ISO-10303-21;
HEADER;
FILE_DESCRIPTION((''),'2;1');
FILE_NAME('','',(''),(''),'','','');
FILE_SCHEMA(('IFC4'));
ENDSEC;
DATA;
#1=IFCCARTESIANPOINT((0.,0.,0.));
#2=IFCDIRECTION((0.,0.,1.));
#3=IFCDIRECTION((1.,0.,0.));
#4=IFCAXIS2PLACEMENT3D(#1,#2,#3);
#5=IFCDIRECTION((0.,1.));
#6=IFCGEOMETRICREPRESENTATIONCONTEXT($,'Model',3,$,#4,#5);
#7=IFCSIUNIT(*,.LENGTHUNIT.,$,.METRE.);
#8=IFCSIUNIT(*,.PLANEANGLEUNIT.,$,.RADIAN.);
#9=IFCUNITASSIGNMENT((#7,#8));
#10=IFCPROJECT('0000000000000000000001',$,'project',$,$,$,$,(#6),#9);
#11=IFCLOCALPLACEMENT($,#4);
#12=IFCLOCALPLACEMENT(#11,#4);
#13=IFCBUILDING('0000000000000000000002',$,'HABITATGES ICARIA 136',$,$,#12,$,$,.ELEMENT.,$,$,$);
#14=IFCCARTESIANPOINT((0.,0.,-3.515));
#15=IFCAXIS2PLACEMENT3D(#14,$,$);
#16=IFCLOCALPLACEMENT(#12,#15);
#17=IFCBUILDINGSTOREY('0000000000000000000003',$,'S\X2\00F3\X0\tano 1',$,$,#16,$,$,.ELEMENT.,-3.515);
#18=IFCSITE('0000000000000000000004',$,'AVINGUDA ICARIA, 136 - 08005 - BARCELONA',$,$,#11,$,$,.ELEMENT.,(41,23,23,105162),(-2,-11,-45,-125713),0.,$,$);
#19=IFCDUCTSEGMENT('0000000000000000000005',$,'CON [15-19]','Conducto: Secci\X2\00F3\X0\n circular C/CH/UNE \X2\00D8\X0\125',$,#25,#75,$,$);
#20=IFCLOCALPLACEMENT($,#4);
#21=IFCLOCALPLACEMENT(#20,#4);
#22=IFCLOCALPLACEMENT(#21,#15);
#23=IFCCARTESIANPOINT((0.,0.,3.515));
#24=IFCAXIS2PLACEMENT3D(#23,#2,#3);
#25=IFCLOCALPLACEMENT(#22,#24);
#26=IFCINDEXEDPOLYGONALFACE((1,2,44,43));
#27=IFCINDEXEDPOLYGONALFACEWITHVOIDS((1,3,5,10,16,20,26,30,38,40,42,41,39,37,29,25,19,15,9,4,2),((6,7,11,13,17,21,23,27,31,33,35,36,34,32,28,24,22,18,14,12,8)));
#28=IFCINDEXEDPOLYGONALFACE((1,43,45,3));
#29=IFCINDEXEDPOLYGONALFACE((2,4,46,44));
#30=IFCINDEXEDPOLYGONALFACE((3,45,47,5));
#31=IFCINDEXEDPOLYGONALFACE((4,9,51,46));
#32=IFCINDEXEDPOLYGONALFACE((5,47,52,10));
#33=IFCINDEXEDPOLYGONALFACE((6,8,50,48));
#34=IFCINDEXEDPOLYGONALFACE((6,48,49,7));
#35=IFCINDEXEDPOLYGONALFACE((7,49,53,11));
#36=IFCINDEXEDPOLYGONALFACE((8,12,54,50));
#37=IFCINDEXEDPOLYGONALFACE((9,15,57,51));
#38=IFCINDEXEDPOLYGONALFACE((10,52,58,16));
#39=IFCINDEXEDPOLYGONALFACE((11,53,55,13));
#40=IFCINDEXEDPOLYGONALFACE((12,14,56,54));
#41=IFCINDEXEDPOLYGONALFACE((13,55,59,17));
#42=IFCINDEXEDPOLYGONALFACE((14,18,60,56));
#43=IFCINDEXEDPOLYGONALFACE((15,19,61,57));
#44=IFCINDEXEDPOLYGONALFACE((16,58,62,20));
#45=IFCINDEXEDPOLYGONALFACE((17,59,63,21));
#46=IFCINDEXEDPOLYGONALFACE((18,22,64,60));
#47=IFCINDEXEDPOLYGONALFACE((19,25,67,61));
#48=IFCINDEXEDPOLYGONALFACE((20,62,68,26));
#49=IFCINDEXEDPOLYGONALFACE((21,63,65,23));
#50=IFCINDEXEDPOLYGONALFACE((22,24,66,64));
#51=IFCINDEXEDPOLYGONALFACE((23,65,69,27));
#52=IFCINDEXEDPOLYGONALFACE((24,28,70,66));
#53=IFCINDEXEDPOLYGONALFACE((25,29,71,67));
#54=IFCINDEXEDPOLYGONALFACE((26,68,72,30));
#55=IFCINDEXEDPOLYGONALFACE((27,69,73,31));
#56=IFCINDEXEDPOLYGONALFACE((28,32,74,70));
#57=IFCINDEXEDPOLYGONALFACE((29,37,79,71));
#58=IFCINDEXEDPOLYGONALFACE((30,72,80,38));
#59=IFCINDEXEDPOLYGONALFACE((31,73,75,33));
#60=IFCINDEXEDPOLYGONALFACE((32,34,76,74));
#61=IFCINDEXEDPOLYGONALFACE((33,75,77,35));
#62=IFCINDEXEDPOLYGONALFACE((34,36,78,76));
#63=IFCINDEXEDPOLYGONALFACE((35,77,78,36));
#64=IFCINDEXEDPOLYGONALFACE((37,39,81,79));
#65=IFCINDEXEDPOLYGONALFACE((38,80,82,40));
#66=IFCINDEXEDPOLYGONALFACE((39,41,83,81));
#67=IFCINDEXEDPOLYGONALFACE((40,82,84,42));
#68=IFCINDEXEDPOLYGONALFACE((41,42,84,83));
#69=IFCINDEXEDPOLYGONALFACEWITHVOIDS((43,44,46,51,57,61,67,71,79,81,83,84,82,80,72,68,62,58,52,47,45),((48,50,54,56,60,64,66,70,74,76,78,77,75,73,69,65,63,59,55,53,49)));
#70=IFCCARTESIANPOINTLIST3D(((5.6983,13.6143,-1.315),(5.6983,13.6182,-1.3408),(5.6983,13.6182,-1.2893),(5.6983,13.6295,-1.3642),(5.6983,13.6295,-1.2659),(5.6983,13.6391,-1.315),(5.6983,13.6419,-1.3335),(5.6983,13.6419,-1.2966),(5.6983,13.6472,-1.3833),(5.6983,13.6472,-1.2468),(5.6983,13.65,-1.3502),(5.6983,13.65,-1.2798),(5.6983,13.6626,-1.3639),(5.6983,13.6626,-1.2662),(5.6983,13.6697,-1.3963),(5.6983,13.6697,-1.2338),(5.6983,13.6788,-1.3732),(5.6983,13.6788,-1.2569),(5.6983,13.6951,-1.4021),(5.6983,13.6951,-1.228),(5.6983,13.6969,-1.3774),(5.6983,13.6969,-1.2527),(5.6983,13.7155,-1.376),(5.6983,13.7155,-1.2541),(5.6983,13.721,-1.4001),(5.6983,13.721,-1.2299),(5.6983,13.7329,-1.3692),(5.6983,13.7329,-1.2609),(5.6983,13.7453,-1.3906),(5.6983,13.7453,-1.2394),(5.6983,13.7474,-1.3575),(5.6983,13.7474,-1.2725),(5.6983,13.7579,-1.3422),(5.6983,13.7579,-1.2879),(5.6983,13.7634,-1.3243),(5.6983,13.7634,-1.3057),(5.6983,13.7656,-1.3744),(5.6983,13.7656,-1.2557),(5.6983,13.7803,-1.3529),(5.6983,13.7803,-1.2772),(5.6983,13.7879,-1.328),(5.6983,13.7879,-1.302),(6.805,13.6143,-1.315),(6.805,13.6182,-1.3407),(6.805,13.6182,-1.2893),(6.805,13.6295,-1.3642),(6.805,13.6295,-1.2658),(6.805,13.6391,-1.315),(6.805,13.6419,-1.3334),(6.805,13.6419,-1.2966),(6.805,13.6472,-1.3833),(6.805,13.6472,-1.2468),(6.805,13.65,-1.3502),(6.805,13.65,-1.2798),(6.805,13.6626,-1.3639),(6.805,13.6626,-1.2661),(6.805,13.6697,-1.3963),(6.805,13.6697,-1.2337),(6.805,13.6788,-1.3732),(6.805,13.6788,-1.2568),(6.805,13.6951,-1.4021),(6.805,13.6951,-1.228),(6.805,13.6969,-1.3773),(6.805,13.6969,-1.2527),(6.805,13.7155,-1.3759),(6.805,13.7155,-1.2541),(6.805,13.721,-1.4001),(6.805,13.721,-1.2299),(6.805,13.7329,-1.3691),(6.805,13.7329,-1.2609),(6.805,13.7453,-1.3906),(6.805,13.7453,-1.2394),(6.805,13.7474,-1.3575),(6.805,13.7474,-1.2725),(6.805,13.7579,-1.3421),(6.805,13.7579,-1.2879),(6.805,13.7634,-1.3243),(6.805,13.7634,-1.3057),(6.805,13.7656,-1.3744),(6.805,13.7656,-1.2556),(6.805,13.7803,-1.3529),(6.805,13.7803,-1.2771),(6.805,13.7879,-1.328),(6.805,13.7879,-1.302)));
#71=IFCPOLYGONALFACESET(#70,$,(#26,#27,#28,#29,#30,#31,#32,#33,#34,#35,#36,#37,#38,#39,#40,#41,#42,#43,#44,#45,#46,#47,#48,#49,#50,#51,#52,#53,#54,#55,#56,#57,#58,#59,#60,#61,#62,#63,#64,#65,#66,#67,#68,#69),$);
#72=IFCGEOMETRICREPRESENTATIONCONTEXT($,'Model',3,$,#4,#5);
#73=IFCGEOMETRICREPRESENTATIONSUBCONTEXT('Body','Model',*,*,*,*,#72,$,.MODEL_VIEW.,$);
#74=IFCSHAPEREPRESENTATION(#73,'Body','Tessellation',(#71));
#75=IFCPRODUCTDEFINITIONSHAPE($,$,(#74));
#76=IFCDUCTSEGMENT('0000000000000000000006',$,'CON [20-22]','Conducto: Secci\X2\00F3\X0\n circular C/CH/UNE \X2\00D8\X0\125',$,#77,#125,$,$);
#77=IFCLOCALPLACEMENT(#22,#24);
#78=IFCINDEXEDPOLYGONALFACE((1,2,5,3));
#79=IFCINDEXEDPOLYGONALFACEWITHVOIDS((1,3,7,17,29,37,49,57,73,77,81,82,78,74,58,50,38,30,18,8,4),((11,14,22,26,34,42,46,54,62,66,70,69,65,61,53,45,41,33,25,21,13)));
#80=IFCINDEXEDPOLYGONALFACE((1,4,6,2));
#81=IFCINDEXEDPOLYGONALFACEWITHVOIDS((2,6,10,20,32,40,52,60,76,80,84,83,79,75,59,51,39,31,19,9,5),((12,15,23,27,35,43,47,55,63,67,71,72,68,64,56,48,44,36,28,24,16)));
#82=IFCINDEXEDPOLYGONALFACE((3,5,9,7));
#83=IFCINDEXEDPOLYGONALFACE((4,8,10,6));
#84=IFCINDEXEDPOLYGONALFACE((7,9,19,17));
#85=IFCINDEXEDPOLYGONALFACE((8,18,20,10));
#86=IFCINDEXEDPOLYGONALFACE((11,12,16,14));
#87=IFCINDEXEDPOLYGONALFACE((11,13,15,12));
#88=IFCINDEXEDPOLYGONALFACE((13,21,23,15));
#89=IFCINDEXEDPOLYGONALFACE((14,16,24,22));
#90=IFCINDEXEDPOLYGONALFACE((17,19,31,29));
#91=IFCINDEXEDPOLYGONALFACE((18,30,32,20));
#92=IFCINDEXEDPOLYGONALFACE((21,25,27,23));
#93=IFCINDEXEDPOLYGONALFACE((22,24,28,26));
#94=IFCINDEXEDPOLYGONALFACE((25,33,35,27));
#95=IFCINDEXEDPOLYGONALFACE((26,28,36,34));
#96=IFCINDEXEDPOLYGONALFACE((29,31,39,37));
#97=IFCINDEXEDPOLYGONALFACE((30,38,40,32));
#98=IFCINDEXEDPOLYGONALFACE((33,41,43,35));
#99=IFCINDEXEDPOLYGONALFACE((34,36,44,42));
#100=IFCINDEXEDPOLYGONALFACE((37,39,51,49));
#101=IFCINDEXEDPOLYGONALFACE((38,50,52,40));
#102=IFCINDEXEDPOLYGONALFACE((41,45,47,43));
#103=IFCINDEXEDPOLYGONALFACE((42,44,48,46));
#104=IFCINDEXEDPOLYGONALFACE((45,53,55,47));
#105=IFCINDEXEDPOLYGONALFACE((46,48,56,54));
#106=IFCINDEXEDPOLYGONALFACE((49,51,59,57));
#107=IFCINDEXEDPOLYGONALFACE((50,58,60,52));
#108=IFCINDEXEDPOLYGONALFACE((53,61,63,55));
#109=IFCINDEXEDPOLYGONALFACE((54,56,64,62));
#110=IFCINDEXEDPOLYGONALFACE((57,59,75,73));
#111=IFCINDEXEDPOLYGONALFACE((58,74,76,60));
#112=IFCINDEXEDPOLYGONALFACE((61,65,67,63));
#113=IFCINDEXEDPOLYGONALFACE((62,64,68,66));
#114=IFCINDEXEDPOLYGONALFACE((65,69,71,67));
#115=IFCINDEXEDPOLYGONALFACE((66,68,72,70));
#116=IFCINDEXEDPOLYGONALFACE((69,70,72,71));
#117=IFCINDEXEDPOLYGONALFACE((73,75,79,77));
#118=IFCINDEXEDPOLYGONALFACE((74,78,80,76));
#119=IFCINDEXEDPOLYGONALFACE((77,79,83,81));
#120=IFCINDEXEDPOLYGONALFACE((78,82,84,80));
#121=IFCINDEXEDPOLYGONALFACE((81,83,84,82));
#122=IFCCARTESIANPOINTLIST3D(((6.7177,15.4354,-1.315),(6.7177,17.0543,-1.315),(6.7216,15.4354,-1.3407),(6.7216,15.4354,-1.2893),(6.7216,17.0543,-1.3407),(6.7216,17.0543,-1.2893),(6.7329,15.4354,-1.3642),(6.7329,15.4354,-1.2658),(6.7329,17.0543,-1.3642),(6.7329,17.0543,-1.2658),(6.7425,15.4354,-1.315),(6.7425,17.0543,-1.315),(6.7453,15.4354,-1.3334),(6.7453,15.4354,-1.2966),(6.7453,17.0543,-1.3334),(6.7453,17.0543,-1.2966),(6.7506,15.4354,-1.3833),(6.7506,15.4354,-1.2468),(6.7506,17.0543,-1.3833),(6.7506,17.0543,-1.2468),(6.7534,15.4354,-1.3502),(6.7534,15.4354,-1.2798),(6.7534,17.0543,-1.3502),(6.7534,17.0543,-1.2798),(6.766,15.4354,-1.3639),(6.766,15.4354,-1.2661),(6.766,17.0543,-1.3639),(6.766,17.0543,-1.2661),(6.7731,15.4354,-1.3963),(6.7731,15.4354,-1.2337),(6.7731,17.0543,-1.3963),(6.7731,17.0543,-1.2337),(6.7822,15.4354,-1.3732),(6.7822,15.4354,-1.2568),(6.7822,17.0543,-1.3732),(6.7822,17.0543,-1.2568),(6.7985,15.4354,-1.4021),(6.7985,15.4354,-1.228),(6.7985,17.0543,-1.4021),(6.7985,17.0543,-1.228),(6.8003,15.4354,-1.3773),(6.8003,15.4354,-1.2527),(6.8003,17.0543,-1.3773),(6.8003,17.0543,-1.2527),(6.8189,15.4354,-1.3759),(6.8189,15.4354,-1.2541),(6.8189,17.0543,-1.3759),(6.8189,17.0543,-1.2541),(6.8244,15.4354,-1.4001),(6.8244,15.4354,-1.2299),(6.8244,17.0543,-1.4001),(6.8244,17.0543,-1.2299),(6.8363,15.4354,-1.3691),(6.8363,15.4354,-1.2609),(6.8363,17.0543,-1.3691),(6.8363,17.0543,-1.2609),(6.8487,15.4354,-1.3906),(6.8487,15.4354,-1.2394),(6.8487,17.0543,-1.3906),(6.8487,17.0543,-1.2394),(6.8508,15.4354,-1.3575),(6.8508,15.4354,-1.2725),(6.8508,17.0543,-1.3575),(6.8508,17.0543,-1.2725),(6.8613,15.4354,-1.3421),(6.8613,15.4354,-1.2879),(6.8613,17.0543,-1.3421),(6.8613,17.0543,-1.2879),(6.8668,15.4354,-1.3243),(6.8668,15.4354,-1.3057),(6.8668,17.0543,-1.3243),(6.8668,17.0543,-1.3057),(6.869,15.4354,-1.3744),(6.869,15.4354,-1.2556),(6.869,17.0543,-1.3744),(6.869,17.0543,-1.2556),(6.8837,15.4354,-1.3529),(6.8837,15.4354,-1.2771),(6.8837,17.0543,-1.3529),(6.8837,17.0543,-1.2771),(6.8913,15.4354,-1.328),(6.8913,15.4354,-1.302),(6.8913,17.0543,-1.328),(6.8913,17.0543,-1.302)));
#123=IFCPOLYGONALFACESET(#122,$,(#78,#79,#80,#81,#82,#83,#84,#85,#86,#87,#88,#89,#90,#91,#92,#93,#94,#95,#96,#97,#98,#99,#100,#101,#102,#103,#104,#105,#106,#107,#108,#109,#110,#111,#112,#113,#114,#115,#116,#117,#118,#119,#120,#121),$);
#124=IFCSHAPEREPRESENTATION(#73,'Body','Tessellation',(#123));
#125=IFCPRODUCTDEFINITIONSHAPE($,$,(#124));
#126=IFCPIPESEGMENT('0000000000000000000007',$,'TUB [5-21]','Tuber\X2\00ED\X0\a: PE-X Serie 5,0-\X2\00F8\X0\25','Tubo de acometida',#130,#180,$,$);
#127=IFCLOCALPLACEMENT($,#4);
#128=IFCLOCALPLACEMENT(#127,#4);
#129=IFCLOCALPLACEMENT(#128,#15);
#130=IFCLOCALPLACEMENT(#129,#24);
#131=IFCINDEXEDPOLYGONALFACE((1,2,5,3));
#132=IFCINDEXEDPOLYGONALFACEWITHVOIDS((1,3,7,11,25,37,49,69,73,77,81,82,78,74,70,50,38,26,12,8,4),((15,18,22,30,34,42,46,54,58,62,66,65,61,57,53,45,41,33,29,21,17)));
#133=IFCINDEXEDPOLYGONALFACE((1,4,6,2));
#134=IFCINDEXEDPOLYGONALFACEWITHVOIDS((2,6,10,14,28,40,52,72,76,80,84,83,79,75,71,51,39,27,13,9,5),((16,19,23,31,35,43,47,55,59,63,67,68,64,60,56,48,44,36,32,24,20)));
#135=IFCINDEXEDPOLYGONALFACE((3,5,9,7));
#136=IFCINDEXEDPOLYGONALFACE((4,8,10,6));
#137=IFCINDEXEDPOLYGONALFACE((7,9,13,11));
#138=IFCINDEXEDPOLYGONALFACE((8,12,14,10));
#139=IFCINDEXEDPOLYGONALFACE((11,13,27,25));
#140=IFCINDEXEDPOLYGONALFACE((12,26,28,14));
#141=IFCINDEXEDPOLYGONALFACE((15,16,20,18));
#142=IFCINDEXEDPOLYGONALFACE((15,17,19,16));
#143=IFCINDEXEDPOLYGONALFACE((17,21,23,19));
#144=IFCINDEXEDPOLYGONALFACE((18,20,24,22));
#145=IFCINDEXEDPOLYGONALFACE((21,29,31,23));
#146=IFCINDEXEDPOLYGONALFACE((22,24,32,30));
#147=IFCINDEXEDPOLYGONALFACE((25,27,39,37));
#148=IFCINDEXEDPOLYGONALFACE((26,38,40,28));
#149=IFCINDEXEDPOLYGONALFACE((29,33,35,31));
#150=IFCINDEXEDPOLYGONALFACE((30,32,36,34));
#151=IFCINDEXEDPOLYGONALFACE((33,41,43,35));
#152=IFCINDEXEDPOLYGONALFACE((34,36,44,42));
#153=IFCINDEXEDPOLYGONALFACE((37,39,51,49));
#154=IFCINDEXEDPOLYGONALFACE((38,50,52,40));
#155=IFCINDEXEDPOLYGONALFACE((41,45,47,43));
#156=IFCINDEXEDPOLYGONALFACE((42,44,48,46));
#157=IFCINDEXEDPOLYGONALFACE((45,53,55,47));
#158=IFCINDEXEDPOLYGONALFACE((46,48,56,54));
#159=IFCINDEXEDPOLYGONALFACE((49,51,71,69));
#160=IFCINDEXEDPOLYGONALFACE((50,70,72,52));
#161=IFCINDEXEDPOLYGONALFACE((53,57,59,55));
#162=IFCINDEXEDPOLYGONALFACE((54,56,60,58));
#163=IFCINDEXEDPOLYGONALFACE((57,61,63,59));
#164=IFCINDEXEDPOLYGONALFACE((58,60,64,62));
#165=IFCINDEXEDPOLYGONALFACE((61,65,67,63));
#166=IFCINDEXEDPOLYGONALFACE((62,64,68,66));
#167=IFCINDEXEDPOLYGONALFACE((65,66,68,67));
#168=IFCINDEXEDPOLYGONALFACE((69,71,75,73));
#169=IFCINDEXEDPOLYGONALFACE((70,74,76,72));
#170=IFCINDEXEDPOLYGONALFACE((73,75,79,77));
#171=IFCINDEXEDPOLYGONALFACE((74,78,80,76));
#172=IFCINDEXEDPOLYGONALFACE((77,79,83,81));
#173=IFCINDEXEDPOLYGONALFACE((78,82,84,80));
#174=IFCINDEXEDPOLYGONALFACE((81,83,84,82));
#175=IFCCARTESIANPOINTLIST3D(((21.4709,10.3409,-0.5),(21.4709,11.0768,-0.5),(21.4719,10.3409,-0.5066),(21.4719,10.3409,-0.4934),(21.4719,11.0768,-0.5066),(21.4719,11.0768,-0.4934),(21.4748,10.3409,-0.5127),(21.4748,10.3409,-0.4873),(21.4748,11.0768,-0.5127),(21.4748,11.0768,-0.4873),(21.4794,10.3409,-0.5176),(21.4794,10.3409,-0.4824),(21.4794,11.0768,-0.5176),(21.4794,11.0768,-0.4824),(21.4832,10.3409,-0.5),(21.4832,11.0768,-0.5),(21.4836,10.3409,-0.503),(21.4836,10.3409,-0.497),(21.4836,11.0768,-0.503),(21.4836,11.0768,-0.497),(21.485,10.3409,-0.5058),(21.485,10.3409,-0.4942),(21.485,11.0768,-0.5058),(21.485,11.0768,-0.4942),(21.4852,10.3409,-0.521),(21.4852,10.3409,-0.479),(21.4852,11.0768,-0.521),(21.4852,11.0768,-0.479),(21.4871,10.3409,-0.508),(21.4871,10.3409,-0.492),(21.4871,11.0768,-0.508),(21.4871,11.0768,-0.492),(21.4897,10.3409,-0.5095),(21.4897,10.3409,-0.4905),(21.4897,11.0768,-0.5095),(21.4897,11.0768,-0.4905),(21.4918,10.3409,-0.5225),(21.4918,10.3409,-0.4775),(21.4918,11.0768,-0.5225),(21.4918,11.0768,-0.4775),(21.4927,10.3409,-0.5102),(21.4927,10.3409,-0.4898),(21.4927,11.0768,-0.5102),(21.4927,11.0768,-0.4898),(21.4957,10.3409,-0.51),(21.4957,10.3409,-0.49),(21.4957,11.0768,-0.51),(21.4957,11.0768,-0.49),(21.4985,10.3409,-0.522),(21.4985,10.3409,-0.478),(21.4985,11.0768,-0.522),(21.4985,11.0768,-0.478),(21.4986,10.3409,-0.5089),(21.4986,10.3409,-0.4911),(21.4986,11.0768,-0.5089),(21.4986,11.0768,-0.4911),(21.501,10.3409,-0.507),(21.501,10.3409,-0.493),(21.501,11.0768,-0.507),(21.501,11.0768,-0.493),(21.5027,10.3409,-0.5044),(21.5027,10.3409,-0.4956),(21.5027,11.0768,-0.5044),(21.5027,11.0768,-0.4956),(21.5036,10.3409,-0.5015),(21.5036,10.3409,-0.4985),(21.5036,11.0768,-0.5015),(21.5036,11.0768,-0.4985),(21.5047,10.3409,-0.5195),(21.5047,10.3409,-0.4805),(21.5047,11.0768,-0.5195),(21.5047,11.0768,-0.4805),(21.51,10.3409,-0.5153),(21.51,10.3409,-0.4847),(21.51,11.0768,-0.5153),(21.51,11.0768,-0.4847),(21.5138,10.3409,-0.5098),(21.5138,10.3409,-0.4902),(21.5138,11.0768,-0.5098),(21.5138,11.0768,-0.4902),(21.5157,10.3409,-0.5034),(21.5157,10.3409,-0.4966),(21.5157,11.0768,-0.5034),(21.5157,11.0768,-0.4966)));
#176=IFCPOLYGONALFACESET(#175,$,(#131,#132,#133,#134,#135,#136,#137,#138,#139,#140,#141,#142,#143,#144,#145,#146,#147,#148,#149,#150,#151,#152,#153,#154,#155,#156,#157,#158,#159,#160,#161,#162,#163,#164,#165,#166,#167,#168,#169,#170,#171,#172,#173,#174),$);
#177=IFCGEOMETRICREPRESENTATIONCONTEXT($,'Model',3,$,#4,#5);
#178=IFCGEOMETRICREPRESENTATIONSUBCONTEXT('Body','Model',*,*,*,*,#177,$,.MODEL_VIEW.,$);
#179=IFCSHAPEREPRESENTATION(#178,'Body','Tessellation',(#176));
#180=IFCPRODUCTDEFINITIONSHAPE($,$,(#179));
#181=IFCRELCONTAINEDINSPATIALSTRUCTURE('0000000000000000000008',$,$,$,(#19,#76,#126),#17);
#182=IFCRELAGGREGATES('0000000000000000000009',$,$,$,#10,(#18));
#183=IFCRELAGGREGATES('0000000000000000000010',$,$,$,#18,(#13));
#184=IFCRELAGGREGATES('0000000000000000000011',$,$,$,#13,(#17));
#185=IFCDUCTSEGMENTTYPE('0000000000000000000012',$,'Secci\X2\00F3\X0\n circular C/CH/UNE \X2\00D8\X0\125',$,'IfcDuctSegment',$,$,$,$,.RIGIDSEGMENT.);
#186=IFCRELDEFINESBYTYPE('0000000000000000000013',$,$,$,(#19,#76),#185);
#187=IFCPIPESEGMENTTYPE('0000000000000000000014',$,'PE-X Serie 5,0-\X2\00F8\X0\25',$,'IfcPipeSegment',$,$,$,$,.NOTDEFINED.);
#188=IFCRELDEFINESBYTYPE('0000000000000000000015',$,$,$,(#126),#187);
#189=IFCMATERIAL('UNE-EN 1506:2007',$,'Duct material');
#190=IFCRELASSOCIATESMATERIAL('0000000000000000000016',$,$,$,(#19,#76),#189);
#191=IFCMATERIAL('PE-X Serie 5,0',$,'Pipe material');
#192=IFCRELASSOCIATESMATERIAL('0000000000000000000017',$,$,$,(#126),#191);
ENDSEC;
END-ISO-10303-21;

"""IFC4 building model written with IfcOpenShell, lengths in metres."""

from ifc_helpers import new_model, si_unit, direction, frame, origin_with_axes, origin_2d_with_axis, place, context, subcontext, project, spatial, hollow_circle, extrude, material, type_object, element, save


model = new_model("IFC4")

# Units and contexts
model_context_1 = context("Model", 3, world=origin_with_axes(), true_north=direction((0.0, 1.0)))
model_context_2 = context("Model", 3, world=origin_with_axes(), true_north=direction((0.0, 1.0)))
model_context_3 = context("Model", 3, world=origin_with_axes(), true_north=direction((0.0, 1.0)))
body_context_1 = subcontext(model_context_2, "Body", "Model", "MODEL_VIEW")
body_context_2 = subcontext(model_context_3, "Body", "Model", "MODEL_VIEW")
ifc_project = project(units=[si_unit("LENGTHUNIT", "METRE"), si_unit("PLANEANGLEUNIT", "RADIAN")], contexts=[model_context_1])

# Site, building, storey
site_placement = place(None, origin_with_axes())
site = spatial("IfcSite", under=ifc_project, at=site_placement, Name="AVINGUDA ICARIA, 136 - 08005 - BARCELONA", CompositionType="ELEMENT", RefLatitude=(41, 23, 23, 105162), RefLongitude=(-2, -11, -45, -125713), RefElevation=0.0)
building_placement = place(site_placement, origin_with_axes())
building = spatial("IfcBuilding", under=site, at=building_placement, Name="HABITATGES ICARIA 136", CompositionType="ELEMENT")
storey_placement = place(building_placement, frame((0.0, 0.0, -3.515)))
storey = spatial("IfcBuildingStorey", under=building, at=storey_placement, Name="Sótano 1", CompositionType="ELEMENT", Elevation=-3.515)

# Duct segments
ifc_material_1 = material(Name="UNE-EN 1506:2007", Category="Duct material")
duct_segment_type = type_object("IfcDuctSegmentType", Name="Sección circular C/CH/UNE Ø125", ApplicableOccurrence="IfcDuctSegment", PredefinedType="RIGIDSEGMENT")
placement_1 = place(None, origin_with_axes())
placement_2 = place(placement_1, origin_with_axes())
placement_3 = place(placement_2, frame((0.0, 0.0, -3.515)))
duct_segment_1_placement = place(placement_3, frame((0.0, 0.0, 3.515), z_axis=(0.0, 0.0, 1.0), x_axis=(1.0, 0.0, 0.0)))
element("IfcDuctSegment", 1, at=duct_segment_1_placement, inside=storey, type_object=duct_segment_type, material=ifc_material_1, Name="CON [15-19]", Description="Conducto: Sección circular C/CH/UNE Ø125", context=body_context_1, shape_type="SweptSolid", body=[
    extrude(hollow_circle(Radius=0.0873, WallThickness=0.0248, at=origin_2d_with_axis()), frame((6.805, 13.7016, -1.315), z_axis=(-1.0, 0.0, -0.000017), x_axis=(0.0, -1.0, 0.0)), (0.0, 0.0, 1.0), 1.1067),
])
duct_segment_2_placement = place(placement_3, frame((0.0, 0.0, 3.515), z_axis=(0.0, 0.0, 1.0), x_axis=(1.0, 0.0, 0.0)))
element("IfcDuctSegment", 2, at=duct_segment_2_placement, inside=storey, type_object=duct_segment_type, material=ifc_material_1, Name="CON [20-22]", Description="Conducto: Sección circular C/CH/UNE Ø125", context=body_context_1, shape_type="SweptSolid", body=[
    extrude(hollow_circle(Radius=0.0873, WallThickness=0.0248, at=origin_2d_with_axis()), frame((6.805, 15.4354, -1.315), z_axis=(0.0, 1.0, 0.0), x_axis=(-1.0, 0.0, 0.0)), (0.0, 0.0, 1.0), 1.6188),
])

# Pipe segment
ifc_material_2 = material(Name="PE-X Serie 5,0", Category="Pipe material")
pipe_segment_type = type_object("IfcPipeSegmentType", Name="PE-X Serie 5,0-ø25", ApplicableOccurrence="IfcPipeSegment", PredefinedType="NOTDEFINED")
placement_4 = place(None, origin_with_axes())
placement_5 = place(placement_4, origin_with_axes())
placement_6 = place(placement_5, frame((0.0, 0.0, -3.515)))
pipe_segment_1_placement = place(placement_6, frame((0.0, 0.0, 3.515), z_axis=(0.0, 0.0, 1.0), x_axis=(1.0, 0.0, 0.0)))
element("IfcPipeSegment", 3, at=pipe_segment_1_placement, inside=storey, type_object=pipe_segment_type, material=ifc_material_2, Name="TUB [5-21]", Description="Tubería: PE-X Serie 5,0-ø25", ObjectType="Tubo de acometida", context=body_context_2, shape_type="SweptSolid", body=[
    extrude(hollow_circle(Radius=0.0226, WallThickness=0.0123, at=origin_2d_with_axis()), frame((21.4934, 10.3409, -0.5), z_axis=(0.0, 1.0, 0.0), x_axis=(-1.0, 0.0, 0.0)), (0.0, 0.0, 1.0), 0.7359),
])

save(model, "model.ifc")
